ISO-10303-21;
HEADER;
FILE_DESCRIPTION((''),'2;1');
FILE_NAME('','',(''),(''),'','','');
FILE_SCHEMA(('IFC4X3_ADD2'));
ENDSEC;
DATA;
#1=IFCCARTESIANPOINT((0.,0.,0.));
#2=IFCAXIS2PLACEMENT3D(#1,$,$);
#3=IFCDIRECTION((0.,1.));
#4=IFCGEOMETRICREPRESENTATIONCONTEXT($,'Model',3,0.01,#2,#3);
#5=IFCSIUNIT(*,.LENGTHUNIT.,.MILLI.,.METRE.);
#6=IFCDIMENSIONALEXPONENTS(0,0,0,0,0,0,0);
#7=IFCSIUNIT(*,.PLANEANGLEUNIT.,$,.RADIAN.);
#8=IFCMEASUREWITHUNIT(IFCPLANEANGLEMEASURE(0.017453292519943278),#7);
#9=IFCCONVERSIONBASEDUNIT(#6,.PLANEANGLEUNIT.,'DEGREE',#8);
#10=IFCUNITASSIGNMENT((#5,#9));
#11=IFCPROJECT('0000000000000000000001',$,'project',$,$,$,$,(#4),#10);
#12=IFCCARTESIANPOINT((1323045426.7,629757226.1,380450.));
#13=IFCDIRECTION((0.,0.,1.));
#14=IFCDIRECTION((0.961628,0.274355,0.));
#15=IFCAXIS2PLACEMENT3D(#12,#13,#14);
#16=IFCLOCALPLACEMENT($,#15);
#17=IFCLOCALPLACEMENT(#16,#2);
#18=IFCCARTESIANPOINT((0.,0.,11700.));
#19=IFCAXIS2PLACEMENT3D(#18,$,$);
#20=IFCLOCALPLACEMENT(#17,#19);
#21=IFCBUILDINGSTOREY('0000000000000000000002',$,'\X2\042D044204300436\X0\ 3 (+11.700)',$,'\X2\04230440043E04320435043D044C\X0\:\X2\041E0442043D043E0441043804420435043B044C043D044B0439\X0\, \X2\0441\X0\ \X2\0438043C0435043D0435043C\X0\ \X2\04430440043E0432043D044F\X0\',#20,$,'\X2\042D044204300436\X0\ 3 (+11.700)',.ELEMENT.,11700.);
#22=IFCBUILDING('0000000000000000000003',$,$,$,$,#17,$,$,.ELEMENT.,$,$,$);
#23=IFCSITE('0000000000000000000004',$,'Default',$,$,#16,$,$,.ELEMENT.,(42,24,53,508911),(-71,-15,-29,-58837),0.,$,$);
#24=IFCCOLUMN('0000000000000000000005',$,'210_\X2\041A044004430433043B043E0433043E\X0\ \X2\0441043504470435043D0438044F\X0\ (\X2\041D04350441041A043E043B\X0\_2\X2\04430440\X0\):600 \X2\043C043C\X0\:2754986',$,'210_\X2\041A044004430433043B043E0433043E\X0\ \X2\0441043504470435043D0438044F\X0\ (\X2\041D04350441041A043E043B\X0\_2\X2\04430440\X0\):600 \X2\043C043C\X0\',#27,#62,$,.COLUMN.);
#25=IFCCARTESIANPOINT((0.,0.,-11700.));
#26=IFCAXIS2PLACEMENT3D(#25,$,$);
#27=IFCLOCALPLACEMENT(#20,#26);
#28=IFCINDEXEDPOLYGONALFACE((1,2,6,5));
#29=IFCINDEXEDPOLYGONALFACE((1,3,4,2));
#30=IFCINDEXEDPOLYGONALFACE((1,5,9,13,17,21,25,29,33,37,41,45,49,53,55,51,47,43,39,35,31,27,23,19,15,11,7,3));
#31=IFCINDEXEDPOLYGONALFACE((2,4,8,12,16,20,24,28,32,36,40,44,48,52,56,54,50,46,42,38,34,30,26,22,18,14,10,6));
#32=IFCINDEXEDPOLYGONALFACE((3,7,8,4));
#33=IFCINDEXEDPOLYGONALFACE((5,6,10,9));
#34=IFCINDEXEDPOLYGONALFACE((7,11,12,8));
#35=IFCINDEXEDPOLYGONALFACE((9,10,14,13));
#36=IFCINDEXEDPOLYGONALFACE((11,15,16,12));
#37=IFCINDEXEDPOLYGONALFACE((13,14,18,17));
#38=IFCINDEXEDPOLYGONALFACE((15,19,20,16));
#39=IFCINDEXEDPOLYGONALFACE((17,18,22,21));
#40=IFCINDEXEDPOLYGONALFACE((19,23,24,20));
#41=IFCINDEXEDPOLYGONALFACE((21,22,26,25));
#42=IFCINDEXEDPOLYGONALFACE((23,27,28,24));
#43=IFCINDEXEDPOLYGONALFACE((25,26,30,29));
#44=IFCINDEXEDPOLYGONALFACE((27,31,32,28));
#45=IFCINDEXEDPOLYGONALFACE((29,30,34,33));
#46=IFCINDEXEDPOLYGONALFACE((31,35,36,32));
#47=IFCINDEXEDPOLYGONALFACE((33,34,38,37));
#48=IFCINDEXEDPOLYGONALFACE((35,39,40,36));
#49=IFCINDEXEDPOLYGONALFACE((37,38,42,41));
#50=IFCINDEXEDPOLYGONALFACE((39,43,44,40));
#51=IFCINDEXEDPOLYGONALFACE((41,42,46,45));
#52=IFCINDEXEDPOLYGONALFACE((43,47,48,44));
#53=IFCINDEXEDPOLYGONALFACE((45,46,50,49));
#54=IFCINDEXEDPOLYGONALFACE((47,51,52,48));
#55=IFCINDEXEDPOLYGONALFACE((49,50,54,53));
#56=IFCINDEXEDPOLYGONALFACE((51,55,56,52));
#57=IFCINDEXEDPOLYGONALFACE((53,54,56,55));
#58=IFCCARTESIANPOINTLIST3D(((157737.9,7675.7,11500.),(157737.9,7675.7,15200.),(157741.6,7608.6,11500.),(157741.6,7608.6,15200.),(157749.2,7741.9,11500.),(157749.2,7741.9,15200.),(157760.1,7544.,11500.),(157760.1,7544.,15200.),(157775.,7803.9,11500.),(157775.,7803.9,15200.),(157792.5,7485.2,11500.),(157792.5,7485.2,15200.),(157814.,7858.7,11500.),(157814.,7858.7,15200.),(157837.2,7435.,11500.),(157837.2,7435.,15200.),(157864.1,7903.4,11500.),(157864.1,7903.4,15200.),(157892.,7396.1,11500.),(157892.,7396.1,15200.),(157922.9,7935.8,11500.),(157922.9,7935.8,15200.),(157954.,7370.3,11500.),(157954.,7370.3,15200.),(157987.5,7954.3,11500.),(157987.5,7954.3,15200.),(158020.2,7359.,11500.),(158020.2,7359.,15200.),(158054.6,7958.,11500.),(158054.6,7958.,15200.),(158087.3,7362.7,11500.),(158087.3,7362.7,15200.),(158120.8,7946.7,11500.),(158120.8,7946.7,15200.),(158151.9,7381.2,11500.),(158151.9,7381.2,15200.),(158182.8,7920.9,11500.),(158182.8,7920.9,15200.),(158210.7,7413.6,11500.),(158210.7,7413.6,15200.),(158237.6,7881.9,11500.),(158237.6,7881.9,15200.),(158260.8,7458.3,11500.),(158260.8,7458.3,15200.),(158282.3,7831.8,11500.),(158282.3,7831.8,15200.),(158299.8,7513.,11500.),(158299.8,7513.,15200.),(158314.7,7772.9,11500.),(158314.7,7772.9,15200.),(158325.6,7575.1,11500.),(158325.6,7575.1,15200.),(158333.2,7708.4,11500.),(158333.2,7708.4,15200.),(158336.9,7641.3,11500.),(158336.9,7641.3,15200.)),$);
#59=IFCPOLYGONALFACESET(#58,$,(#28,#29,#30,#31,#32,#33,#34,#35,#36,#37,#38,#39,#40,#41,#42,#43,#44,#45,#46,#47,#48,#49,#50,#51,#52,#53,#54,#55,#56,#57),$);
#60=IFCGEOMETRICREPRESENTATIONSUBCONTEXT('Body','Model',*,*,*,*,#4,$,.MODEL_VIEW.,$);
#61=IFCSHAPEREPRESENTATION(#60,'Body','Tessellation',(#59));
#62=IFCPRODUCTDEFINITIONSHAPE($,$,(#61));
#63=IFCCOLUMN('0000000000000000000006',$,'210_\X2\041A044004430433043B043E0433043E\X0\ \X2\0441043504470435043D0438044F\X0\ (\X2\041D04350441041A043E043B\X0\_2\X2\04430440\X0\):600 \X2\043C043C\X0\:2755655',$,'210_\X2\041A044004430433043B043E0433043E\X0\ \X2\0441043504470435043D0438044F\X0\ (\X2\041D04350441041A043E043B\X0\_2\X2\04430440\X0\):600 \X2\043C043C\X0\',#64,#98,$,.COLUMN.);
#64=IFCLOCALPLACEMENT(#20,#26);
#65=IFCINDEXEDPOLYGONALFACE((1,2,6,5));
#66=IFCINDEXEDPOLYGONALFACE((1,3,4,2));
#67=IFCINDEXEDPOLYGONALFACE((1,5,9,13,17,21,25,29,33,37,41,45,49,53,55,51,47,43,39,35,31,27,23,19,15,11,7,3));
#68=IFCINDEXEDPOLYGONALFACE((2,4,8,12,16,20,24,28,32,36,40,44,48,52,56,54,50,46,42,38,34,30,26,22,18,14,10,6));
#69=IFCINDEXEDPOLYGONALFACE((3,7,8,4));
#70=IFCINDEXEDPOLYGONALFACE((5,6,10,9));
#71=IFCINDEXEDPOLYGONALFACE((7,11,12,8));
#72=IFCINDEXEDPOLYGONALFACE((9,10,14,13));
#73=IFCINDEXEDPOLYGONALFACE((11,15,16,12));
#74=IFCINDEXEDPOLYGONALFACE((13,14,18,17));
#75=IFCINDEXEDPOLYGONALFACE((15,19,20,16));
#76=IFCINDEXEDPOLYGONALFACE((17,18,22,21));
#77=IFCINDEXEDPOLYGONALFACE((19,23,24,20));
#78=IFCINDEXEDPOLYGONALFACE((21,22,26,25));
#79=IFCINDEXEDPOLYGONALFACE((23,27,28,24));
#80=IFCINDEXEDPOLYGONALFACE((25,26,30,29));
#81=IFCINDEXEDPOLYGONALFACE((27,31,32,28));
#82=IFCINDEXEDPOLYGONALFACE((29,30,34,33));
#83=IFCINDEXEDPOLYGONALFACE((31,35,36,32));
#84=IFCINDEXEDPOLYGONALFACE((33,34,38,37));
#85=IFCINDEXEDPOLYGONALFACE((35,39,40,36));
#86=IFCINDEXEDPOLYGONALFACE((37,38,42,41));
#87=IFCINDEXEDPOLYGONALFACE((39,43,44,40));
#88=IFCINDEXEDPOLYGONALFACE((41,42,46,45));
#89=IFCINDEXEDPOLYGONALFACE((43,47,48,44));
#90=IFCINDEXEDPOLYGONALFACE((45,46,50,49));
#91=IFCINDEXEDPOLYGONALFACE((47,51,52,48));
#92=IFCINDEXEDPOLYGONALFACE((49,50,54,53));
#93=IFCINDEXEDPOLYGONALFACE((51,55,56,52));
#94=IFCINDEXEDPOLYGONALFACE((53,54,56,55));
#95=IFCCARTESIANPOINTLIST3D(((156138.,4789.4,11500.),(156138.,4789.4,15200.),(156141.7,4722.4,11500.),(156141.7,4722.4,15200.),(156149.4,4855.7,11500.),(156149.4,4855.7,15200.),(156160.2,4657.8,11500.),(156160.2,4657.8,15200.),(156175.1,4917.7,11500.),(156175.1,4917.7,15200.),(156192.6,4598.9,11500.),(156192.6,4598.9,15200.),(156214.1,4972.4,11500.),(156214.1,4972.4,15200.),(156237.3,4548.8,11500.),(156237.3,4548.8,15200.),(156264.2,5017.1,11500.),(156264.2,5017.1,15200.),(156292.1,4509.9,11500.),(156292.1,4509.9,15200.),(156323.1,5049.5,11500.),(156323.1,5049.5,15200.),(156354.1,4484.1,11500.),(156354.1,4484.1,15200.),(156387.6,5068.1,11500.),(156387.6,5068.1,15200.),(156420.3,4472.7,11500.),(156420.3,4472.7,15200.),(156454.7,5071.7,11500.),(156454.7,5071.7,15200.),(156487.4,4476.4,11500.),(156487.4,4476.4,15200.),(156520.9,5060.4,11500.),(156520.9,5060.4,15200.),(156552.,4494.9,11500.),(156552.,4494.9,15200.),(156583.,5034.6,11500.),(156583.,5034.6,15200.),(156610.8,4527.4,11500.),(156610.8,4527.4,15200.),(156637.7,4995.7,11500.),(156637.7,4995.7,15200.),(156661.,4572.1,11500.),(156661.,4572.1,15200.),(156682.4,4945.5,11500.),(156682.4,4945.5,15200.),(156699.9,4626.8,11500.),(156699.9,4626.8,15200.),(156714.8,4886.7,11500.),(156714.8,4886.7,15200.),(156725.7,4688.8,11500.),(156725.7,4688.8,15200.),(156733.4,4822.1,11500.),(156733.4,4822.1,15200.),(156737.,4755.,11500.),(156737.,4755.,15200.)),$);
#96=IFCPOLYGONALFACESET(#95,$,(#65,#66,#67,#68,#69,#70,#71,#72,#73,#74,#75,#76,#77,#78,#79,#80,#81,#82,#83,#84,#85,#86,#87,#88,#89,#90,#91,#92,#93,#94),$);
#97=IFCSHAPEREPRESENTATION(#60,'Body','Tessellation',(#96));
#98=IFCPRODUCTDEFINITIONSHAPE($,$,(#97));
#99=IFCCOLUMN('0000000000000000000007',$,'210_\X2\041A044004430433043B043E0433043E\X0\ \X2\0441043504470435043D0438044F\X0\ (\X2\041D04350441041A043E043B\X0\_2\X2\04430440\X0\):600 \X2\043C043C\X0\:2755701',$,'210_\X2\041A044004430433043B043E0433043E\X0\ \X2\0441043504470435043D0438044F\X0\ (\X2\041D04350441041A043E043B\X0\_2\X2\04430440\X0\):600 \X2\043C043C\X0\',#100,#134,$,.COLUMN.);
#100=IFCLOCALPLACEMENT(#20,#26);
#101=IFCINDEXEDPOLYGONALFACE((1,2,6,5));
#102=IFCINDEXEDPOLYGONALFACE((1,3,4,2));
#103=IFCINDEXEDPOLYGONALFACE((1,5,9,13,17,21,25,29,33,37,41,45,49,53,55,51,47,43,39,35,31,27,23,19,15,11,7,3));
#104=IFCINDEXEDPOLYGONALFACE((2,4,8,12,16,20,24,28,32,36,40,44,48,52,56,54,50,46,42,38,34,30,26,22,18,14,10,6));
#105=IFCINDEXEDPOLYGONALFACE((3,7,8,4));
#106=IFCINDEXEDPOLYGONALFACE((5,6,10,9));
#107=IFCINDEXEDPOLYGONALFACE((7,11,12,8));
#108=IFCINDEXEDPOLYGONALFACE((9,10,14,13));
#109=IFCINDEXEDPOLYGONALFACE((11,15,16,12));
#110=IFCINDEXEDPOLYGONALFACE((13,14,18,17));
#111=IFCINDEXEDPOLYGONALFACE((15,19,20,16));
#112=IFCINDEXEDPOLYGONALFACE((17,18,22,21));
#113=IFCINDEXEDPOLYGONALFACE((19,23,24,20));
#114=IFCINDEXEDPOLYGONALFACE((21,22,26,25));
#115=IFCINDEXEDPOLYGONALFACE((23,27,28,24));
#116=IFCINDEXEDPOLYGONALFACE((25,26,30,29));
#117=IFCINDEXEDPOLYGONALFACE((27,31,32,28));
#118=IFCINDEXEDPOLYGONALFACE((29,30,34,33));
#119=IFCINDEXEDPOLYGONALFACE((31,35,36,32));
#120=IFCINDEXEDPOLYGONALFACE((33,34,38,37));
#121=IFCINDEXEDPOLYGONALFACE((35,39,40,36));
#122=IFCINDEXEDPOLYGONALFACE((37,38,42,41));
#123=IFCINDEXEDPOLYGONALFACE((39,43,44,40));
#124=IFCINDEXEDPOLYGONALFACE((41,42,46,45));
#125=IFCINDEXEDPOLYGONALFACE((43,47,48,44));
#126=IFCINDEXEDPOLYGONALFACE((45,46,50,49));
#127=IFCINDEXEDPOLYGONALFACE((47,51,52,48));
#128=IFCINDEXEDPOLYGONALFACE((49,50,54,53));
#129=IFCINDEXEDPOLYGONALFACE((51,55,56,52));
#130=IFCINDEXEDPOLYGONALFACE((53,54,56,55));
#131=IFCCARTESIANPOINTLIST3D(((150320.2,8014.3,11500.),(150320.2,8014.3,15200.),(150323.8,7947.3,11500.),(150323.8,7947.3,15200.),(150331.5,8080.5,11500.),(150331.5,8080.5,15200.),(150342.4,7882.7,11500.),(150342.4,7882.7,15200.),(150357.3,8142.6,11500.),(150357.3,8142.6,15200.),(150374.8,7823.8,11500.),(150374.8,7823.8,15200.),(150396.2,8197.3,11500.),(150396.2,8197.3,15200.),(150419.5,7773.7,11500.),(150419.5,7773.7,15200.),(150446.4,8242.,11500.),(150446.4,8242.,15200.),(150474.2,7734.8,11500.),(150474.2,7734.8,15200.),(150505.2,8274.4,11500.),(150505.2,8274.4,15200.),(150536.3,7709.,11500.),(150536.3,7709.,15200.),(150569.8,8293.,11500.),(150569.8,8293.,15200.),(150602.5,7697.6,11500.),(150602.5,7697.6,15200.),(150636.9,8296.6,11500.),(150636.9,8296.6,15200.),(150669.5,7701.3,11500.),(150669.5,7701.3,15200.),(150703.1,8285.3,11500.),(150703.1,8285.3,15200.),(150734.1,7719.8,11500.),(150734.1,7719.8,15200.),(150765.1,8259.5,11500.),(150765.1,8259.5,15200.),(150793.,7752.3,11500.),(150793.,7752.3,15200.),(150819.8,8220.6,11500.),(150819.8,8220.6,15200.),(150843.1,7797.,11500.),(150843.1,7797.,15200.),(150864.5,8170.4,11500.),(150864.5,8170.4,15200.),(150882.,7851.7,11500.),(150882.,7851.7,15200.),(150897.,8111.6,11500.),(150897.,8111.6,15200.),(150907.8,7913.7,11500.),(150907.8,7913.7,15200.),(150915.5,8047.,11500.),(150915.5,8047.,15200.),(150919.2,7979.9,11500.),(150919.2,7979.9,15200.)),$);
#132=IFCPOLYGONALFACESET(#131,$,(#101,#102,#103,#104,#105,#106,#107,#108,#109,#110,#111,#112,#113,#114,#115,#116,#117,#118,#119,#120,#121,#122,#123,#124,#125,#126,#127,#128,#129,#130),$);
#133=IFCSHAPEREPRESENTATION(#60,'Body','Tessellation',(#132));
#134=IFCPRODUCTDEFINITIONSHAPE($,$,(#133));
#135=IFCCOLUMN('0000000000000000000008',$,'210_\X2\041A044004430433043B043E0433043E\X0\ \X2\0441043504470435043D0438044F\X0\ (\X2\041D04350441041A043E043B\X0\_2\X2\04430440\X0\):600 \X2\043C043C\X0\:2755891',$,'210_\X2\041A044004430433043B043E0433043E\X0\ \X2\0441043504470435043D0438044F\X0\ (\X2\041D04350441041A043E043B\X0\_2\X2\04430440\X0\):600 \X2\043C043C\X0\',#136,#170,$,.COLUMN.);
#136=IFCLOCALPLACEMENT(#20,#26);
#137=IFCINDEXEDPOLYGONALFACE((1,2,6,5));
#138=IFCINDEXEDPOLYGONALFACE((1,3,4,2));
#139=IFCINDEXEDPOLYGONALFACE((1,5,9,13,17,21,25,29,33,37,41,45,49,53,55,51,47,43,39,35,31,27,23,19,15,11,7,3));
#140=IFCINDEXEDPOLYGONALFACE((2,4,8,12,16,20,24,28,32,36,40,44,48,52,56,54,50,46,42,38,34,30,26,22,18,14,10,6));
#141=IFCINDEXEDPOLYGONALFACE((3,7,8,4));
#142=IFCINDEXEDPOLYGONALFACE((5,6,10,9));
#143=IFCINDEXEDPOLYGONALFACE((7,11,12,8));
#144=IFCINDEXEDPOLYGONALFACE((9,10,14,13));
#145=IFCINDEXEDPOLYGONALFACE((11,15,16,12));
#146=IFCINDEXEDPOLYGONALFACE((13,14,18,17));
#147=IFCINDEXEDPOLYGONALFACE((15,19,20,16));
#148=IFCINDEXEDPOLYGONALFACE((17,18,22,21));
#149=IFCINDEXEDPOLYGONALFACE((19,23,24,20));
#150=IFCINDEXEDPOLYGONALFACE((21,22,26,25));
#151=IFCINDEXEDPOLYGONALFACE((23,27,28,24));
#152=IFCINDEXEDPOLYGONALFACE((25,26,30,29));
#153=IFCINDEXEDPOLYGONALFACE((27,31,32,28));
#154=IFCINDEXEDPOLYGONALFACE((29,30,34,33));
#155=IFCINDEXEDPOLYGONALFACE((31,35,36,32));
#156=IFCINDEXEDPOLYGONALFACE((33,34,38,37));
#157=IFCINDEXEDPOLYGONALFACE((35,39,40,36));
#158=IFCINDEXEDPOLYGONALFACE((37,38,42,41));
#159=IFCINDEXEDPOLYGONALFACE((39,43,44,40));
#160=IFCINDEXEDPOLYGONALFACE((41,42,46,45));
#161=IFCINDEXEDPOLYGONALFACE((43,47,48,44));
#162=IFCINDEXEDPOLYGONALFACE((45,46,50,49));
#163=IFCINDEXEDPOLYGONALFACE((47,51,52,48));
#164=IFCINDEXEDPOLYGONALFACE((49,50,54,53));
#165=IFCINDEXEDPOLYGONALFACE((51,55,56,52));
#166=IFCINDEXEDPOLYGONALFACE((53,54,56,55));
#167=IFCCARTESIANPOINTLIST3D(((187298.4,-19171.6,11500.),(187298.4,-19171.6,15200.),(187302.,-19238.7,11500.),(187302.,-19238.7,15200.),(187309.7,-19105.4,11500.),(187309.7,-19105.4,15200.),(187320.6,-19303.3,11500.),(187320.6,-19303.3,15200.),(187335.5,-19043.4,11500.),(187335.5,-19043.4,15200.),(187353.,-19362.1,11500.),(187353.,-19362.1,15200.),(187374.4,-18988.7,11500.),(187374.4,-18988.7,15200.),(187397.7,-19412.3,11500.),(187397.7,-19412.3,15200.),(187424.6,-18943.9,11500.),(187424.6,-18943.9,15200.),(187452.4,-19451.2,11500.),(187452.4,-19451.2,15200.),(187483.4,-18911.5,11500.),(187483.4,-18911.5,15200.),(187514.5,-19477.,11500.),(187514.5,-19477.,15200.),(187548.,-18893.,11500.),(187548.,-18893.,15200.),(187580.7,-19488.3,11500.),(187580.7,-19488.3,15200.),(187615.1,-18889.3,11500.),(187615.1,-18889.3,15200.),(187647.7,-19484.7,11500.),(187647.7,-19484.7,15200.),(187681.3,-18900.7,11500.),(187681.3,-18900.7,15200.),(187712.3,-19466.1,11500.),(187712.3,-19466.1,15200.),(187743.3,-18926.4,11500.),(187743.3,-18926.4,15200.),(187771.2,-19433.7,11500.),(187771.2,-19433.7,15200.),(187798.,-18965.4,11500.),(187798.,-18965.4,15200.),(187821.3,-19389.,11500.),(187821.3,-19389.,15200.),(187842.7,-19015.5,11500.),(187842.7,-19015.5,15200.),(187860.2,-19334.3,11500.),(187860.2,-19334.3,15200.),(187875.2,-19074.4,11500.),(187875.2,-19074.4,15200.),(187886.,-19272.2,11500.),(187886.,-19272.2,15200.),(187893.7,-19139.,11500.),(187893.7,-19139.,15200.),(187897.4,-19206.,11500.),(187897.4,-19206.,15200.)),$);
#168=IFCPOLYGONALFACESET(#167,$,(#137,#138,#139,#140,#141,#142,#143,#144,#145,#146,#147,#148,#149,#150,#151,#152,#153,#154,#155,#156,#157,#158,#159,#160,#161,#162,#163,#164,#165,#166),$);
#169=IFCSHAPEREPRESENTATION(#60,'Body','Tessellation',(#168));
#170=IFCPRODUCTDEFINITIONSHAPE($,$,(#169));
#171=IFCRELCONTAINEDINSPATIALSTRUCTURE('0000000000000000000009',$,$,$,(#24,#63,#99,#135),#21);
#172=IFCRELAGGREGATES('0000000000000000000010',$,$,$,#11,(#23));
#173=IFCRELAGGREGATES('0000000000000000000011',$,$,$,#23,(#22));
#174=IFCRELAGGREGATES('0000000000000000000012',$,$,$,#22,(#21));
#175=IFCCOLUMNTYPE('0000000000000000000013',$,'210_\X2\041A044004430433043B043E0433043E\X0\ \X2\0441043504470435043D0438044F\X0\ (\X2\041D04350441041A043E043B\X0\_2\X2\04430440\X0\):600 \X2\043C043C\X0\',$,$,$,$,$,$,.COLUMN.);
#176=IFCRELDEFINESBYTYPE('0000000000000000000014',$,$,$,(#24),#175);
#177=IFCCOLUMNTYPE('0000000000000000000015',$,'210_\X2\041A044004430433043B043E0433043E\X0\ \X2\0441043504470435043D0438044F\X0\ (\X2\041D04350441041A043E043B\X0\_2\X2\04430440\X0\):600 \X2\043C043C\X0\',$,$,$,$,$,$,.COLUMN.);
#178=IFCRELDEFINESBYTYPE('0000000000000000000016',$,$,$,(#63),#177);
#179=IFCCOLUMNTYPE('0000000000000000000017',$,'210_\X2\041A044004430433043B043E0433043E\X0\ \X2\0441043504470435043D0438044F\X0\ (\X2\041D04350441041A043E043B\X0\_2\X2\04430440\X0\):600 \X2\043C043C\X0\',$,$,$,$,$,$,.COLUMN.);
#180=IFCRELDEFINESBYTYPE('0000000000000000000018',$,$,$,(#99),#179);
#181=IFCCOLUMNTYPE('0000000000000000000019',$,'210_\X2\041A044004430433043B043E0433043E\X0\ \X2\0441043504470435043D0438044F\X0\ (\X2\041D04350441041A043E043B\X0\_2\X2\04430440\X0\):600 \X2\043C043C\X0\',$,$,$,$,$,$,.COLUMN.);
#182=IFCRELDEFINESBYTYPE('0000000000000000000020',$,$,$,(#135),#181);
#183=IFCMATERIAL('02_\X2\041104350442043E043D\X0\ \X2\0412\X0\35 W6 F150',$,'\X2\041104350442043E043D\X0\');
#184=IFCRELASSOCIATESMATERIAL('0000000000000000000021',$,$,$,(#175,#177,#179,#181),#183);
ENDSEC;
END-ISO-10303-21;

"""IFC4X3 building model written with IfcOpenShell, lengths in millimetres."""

from ifc_helpers import new_model, entity, si_unit, converted_unit, direction, frame, frame_2d, origin, origin_2d_with_axis, place, context, subcontext, project, spatial, circle, extrude, source, transform, mapped, material, material_profile, profile_set, type_object, type_shapes, element, save


model = new_model("IFC4X3")

# Units and contexts
model_context = context("Model", 3, precision=0.01, world=origin(), true_north=direction((0.0, 1.0)))
body_context = subcontext(model_context, "Body", "Model", "MODEL_VIEW")
ifc_project = project(units=[si_unit("LENGTHUNIT", "METRE", prefix="MILLI"), converted_unit("PLANEANGLEUNIT", "DEGREE", entity("IfcPlaneAngleMeasure", 0.017453292519943278), si_unit("PLANEANGLEUNIT", "RADIAN"), dimensions=[0, 0, 0, 0, 0, 0, 0])], contexts=[model_context])

# Site, building, storey
site_placement = place(None, frame((1323045426.7, 629757226.1, 380450.0), z_axis=(0.0, 0.0, 1.0), x_axis=(0.961628, 0.274355, 0.0)))
site = spatial("IfcSite", under=ifc_project, at=site_placement, Name="Default", CompositionType="ELEMENT", RefLatitude=(42, 24, 53, 508911), RefLongitude=(-71, -15, -29, -58837), RefElevation=0.0)
building_placement = place(site_placement, origin())
building = spatial("IfcBuilding", under=site, at=building_placement, CompositionType="ELEMENT")
storey_placement = place(building_placement, frame((0.0, 0.0, 11700.0)))
storey = spatial("IfcBuildingStorey", under=building, at=storey_placement, Name="Этаж 3 (+11.700)", ObjectType="Уровень:Относительный, с именем уровня", LongName="Этаж 3 (+11.700)", CompositionType="ELEMENT", Elevation=11700.0)

# Columns
ifc_material = material(Name="02_Бетон В35 W6 F150", Category="Бетон")
ifc_material_profile_1 = material_profile(ifc_material, circle(Radius=300.0, at=origin_2d_with_axis()), Name="600 мм")
ifc_profile_set_1 = profile_set([ifc_material_profile_1], Name="600 мм")
column_type_1 = type_object("IfcColumnType", Name="210_Круглого сечения (НесКол_2ур):600 мм", PredefinedType="COLUMN", material=ifc_profile_set_1)
shared_shape_1 = source(origin(), body_context, "Body", "SweptSolid", [
    extrude(circle(Radius=300.0, at=origin_2d_with_axis()), frame((158037.4, 7658.5, 11500.0), z_axis=(0.0, 0.0, 1.0), x_axis=(0.87462, -0.48481, 0.0)), (0.0, 0.0, 1.0), 3700.0),
])
type_shapes(column_type_1, [shared_shape_1])
column_1_placement = place(storey_placement, frame((0.0, 0.0, -11700.0)))
element("IfcColumn", 1, at=column_1_placement, inside=storey, type_object=column_type_1, Name="210_Круглого сечения (НесКол_2ур):600 мм:2754986", ObjectType="210_Круглого сечения (НесКол_2ур):600 мм", PredefinedType="COLUMN", context=body_context, shape_type="MappedRepresentation", body=[
    mapped(shared_shape_1, transform((0.0, 0.0, 0.0), scale=1.0)),
])
column_type_2 = type_object("IfcColumnType", Name="210_Круглого сечения (НесКол_2ур):600 мм", PredefinedType="COLUMN", material=ifc_profile_set_1)
shared_shape_2 = source(origin(), body_context, "Body", "SweptSolid", [
    extrude(circle(Radius=300.0, at=frame_2d((0.0, 0.0), x_axis=(1.0, 0.0))), frame((156437.5, 4772.2, 11500.0), z_axis=(0.0, 0.0, 1.0), x_axis=(0.87462, -0.48481, 0.0)), (0.0, 0.0, 1.0), 3700.0),
])
type_shapes(column_type_2, [shared_shape_2])
column_2_placement = place(storey_placement, frame((0.0, 0.0, -11700.0)))
element("IfcColumn", 2, at=column_2_placement, inside=storey, type_object=column_type_2, Name="210_Круглого сечения (НесКол_2ур):600 мм:2755655", ObjectType="210_Круглого сечения (НесКол_2ур):600 мм", PredefinedType="COLUMN", context=body_context, shape_type="MappedRepresentation", body=[
    mapped(shared_shape_2, transform((0.0, 0.0, 0.0), scale=1.0)),
])
column_type_3 = type_object("IfcColumnType", Name="210_Круглого сечения (НесКол_2ур):600 мм", PredefinedType="COLUMN", material=ifc_profile_set_1)
shared_shape_3 = source(origin(), body_context, "Body", "SweptSolid", [
    extrude(circle(Radius=300.0, at=origin_2d_with_axis()), frame((150619.7, 7997.1, 11500.0), z_axis=(0.0, 0.0, 1.0), x_axis=(0.87462, -0.48481, 0.0)), (0.0, 0.0, 1.0), 3700.0),
])
type_shapes(column_type_3, [shared_shape_3])
column_3_placement = place(storey_placement, frame((0.0, 0.0, -11700.0)))
element("IfcColumn", 3, at=column_3_placement, inside=storey, type_object=column_type_3, Name="210_Круглого сечения (НесКол_2ур):600 мм:2755701", ObjectType="210_Круглого сечения (НесКол_2ур):600 мм", PredefinedType="COLUMN", context=body_context, shape_type="MappedRepresentation", body=[
    mapped(shared_shape_3, transform((0.0, 0.0, 0.0), scale=1.0)),
])
column_type_4 = type_object("IfcColumnType", Name="210_Круглого сечения (НесКол_2ур):600 мм", PredefinedType="COLUMN", material=ifc_profile_set_1)
shared_shape_4 = source(origin(), body_context, "Body", "SweptSolid", [
    extrude(circle(Radius=300.0, at=origin_2d_with_axis()), frame((187597.9, -19188.8, 11500.0), z_axis=(0.0, 0.0, 1.0), x_axis=(0.87462, -0.48481, 0.0)), (0.0, 0.0, 1.0), 3700.0),
])
type_shapes(column_type_4, [shared_shape_4])
column_4_placement = place(storey_placement, frame((0.0, 0.0, -11700.0)))
element("IfcColumn", 4, at=column_4_placement, inside=storey, type_object=column_type_4, Name="210_Круглого сечения (НесКол_2ур):600 мм:2755891", ObjectType="210_Круглого сечения (НесКол_2ур):600 мм", PredefinedType="COLUMN", context=body_context, shape_type="MappedRepresentation", body=[
    mapped(shared_shape_4, transform((0.0, 0.0, 0.0), scale=1.0)),
])

save(model, "model.ifc")
